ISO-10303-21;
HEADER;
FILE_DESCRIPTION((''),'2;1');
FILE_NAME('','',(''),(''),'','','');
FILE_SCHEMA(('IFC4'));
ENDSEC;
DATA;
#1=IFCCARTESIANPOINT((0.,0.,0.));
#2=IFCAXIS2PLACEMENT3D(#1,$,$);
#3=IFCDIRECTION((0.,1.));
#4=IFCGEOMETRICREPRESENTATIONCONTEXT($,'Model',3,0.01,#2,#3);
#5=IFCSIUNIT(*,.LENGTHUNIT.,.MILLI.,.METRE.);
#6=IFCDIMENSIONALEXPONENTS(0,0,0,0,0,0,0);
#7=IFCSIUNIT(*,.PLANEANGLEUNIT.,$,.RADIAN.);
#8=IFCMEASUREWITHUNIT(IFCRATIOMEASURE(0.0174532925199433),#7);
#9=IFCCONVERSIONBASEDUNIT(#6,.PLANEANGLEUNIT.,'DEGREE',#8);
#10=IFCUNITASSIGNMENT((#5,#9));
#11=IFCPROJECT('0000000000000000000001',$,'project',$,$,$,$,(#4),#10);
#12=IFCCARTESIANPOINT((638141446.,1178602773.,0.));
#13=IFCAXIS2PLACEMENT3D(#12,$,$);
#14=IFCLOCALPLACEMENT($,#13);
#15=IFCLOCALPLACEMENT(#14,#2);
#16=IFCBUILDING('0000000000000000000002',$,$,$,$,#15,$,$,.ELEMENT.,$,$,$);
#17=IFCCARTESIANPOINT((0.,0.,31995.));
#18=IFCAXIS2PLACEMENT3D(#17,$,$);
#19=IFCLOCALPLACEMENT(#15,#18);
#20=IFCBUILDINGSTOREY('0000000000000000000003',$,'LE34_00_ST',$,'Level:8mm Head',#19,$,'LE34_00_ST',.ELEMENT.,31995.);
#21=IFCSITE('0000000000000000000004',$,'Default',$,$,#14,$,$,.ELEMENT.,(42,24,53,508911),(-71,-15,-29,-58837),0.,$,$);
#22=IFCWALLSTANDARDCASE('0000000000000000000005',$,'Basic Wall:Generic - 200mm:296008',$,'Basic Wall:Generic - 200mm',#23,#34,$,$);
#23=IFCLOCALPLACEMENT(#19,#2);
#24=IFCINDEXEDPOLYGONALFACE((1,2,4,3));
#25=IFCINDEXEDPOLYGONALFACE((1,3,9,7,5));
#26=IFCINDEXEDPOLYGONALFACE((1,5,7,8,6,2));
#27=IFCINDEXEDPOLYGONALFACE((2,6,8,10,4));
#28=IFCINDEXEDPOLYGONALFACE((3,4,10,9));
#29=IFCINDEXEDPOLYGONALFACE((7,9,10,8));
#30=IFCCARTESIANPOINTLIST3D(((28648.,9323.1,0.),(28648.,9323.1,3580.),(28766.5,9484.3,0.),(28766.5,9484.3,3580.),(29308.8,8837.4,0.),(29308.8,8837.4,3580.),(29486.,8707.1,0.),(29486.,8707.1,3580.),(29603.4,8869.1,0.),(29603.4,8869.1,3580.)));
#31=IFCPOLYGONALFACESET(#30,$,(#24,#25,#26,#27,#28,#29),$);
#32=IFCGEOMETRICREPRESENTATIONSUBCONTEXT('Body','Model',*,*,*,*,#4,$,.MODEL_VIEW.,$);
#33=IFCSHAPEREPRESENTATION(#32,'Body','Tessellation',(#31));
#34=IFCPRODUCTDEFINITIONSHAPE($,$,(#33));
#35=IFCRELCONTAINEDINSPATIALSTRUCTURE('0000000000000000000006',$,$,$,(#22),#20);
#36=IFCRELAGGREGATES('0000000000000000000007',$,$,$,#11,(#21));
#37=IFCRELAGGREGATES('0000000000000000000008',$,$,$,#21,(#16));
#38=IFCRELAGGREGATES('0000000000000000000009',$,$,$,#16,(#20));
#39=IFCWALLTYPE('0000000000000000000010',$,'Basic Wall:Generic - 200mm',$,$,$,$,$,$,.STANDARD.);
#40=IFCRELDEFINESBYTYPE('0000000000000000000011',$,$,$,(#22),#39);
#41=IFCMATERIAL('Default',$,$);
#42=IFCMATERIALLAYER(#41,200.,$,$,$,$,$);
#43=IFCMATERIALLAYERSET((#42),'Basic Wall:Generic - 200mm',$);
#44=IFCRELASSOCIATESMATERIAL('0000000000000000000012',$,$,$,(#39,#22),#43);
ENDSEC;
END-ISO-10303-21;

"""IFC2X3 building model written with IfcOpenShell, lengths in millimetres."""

from ifc_helpers import new_model, entity, si_unit, converted_unit, direction, frame, origin, place, context, subcontext, project, spatial, polyline, outline, extrude, material, layer, layer_set, layer_usage, type_object, element, save


model = new_model("IFC2X3")

# Units and contexts
model_context = context("Model", 3, precision=0.01, world=origin(), true_north=direction((0.0, 1.0)))
body_context = subcontext(model_context, "Body", "Model", "MODEL_VIEW")
ifc_project = project(units=[si_unit("LENGTHUNIT", "METRE", prefix="MILLI"), converted_unit("PLANEANGLEUNIT", "DEGREE", entity("IfcRatioMeasure", 0.0174532925199433), si_unit("PLANEANGLEUNIT", "RADIAN"), dimensions=[0, 0, 0, 0, 0, 0, 0])], contexts=[model_context])

# Site, building, storey
site_placement = place(None, frame((638141446.0, 1178602773.0, 0.0)))
site = spatial("IfcSite", under=ifc_project, at=site_placement, Name="Default", CompositionType="ELEMENT", RefLatitude=(42, 24, 53, 508911), RefLongitude=(-71, -15, -29, -58837), RefElevation=0.0)
building_placement = place(site_placement, origin())
building = spatial("IfcBuilding", under=site, at=building_placement, CompositionType="ELEMENT")
storey_placement = place(building_placement, frame((0.0, 0.0, 31995.0)))
storey = spatial("IfcBuildingStorey", under=building, at=storey_placement, Name="LE34_00_ST", ObjectType="Level:8mm Head", LongName="LE34_00_ST", CompositionType="ELEMENT", Elevation=31995.0)

# Wall
ifc_material = material(Name="Default")
ifc_layer_1 = layer(ifc_material, 200.0)
ifc_layer_set_1 = layer_set([ifc_layer_1], Name="Basic Wall:Generic - 200mm")
ifc_layer_usage_1 = layer_usage(ifc_layer_set_1, "AXIS2", "NEGATIVE", 100.0)
wall_type_1 = type_object("IfcWallType", Name="Basic Wall:Generic - 200mm", PredefinedType="STANDARD", material=ifc_layer_set_1)
wall_1_placement = place(storey_placement, frame((28707.3, 9403.7, 0.0), z_axis=(0.0, 0.0, 1.0), x_axis=(0.805709, -0.592312, 0.0)))
element("IfcWallStandardCase", 1, at=wall_1_placement, inside=storey, type_object=wall_type_1, material=ifc_layer_usage_1, Name="Basic Wall:Generic - 200mm:296008", ObjectType="Basic Wall:Generic - 200mm", context=body_context, shape_type="SweptSolid", body=[
    extrude(outline(polyline([(1040.1, -100.0), (1038.7, 100.0), (0.0, 100.0), (0.0, -100.0), (820.1, -100.0), (1040.1, -100.0)])), origin(), (0.0, 0.0, 1.0), 3580.0),
])

save(model, "model.ifc")
